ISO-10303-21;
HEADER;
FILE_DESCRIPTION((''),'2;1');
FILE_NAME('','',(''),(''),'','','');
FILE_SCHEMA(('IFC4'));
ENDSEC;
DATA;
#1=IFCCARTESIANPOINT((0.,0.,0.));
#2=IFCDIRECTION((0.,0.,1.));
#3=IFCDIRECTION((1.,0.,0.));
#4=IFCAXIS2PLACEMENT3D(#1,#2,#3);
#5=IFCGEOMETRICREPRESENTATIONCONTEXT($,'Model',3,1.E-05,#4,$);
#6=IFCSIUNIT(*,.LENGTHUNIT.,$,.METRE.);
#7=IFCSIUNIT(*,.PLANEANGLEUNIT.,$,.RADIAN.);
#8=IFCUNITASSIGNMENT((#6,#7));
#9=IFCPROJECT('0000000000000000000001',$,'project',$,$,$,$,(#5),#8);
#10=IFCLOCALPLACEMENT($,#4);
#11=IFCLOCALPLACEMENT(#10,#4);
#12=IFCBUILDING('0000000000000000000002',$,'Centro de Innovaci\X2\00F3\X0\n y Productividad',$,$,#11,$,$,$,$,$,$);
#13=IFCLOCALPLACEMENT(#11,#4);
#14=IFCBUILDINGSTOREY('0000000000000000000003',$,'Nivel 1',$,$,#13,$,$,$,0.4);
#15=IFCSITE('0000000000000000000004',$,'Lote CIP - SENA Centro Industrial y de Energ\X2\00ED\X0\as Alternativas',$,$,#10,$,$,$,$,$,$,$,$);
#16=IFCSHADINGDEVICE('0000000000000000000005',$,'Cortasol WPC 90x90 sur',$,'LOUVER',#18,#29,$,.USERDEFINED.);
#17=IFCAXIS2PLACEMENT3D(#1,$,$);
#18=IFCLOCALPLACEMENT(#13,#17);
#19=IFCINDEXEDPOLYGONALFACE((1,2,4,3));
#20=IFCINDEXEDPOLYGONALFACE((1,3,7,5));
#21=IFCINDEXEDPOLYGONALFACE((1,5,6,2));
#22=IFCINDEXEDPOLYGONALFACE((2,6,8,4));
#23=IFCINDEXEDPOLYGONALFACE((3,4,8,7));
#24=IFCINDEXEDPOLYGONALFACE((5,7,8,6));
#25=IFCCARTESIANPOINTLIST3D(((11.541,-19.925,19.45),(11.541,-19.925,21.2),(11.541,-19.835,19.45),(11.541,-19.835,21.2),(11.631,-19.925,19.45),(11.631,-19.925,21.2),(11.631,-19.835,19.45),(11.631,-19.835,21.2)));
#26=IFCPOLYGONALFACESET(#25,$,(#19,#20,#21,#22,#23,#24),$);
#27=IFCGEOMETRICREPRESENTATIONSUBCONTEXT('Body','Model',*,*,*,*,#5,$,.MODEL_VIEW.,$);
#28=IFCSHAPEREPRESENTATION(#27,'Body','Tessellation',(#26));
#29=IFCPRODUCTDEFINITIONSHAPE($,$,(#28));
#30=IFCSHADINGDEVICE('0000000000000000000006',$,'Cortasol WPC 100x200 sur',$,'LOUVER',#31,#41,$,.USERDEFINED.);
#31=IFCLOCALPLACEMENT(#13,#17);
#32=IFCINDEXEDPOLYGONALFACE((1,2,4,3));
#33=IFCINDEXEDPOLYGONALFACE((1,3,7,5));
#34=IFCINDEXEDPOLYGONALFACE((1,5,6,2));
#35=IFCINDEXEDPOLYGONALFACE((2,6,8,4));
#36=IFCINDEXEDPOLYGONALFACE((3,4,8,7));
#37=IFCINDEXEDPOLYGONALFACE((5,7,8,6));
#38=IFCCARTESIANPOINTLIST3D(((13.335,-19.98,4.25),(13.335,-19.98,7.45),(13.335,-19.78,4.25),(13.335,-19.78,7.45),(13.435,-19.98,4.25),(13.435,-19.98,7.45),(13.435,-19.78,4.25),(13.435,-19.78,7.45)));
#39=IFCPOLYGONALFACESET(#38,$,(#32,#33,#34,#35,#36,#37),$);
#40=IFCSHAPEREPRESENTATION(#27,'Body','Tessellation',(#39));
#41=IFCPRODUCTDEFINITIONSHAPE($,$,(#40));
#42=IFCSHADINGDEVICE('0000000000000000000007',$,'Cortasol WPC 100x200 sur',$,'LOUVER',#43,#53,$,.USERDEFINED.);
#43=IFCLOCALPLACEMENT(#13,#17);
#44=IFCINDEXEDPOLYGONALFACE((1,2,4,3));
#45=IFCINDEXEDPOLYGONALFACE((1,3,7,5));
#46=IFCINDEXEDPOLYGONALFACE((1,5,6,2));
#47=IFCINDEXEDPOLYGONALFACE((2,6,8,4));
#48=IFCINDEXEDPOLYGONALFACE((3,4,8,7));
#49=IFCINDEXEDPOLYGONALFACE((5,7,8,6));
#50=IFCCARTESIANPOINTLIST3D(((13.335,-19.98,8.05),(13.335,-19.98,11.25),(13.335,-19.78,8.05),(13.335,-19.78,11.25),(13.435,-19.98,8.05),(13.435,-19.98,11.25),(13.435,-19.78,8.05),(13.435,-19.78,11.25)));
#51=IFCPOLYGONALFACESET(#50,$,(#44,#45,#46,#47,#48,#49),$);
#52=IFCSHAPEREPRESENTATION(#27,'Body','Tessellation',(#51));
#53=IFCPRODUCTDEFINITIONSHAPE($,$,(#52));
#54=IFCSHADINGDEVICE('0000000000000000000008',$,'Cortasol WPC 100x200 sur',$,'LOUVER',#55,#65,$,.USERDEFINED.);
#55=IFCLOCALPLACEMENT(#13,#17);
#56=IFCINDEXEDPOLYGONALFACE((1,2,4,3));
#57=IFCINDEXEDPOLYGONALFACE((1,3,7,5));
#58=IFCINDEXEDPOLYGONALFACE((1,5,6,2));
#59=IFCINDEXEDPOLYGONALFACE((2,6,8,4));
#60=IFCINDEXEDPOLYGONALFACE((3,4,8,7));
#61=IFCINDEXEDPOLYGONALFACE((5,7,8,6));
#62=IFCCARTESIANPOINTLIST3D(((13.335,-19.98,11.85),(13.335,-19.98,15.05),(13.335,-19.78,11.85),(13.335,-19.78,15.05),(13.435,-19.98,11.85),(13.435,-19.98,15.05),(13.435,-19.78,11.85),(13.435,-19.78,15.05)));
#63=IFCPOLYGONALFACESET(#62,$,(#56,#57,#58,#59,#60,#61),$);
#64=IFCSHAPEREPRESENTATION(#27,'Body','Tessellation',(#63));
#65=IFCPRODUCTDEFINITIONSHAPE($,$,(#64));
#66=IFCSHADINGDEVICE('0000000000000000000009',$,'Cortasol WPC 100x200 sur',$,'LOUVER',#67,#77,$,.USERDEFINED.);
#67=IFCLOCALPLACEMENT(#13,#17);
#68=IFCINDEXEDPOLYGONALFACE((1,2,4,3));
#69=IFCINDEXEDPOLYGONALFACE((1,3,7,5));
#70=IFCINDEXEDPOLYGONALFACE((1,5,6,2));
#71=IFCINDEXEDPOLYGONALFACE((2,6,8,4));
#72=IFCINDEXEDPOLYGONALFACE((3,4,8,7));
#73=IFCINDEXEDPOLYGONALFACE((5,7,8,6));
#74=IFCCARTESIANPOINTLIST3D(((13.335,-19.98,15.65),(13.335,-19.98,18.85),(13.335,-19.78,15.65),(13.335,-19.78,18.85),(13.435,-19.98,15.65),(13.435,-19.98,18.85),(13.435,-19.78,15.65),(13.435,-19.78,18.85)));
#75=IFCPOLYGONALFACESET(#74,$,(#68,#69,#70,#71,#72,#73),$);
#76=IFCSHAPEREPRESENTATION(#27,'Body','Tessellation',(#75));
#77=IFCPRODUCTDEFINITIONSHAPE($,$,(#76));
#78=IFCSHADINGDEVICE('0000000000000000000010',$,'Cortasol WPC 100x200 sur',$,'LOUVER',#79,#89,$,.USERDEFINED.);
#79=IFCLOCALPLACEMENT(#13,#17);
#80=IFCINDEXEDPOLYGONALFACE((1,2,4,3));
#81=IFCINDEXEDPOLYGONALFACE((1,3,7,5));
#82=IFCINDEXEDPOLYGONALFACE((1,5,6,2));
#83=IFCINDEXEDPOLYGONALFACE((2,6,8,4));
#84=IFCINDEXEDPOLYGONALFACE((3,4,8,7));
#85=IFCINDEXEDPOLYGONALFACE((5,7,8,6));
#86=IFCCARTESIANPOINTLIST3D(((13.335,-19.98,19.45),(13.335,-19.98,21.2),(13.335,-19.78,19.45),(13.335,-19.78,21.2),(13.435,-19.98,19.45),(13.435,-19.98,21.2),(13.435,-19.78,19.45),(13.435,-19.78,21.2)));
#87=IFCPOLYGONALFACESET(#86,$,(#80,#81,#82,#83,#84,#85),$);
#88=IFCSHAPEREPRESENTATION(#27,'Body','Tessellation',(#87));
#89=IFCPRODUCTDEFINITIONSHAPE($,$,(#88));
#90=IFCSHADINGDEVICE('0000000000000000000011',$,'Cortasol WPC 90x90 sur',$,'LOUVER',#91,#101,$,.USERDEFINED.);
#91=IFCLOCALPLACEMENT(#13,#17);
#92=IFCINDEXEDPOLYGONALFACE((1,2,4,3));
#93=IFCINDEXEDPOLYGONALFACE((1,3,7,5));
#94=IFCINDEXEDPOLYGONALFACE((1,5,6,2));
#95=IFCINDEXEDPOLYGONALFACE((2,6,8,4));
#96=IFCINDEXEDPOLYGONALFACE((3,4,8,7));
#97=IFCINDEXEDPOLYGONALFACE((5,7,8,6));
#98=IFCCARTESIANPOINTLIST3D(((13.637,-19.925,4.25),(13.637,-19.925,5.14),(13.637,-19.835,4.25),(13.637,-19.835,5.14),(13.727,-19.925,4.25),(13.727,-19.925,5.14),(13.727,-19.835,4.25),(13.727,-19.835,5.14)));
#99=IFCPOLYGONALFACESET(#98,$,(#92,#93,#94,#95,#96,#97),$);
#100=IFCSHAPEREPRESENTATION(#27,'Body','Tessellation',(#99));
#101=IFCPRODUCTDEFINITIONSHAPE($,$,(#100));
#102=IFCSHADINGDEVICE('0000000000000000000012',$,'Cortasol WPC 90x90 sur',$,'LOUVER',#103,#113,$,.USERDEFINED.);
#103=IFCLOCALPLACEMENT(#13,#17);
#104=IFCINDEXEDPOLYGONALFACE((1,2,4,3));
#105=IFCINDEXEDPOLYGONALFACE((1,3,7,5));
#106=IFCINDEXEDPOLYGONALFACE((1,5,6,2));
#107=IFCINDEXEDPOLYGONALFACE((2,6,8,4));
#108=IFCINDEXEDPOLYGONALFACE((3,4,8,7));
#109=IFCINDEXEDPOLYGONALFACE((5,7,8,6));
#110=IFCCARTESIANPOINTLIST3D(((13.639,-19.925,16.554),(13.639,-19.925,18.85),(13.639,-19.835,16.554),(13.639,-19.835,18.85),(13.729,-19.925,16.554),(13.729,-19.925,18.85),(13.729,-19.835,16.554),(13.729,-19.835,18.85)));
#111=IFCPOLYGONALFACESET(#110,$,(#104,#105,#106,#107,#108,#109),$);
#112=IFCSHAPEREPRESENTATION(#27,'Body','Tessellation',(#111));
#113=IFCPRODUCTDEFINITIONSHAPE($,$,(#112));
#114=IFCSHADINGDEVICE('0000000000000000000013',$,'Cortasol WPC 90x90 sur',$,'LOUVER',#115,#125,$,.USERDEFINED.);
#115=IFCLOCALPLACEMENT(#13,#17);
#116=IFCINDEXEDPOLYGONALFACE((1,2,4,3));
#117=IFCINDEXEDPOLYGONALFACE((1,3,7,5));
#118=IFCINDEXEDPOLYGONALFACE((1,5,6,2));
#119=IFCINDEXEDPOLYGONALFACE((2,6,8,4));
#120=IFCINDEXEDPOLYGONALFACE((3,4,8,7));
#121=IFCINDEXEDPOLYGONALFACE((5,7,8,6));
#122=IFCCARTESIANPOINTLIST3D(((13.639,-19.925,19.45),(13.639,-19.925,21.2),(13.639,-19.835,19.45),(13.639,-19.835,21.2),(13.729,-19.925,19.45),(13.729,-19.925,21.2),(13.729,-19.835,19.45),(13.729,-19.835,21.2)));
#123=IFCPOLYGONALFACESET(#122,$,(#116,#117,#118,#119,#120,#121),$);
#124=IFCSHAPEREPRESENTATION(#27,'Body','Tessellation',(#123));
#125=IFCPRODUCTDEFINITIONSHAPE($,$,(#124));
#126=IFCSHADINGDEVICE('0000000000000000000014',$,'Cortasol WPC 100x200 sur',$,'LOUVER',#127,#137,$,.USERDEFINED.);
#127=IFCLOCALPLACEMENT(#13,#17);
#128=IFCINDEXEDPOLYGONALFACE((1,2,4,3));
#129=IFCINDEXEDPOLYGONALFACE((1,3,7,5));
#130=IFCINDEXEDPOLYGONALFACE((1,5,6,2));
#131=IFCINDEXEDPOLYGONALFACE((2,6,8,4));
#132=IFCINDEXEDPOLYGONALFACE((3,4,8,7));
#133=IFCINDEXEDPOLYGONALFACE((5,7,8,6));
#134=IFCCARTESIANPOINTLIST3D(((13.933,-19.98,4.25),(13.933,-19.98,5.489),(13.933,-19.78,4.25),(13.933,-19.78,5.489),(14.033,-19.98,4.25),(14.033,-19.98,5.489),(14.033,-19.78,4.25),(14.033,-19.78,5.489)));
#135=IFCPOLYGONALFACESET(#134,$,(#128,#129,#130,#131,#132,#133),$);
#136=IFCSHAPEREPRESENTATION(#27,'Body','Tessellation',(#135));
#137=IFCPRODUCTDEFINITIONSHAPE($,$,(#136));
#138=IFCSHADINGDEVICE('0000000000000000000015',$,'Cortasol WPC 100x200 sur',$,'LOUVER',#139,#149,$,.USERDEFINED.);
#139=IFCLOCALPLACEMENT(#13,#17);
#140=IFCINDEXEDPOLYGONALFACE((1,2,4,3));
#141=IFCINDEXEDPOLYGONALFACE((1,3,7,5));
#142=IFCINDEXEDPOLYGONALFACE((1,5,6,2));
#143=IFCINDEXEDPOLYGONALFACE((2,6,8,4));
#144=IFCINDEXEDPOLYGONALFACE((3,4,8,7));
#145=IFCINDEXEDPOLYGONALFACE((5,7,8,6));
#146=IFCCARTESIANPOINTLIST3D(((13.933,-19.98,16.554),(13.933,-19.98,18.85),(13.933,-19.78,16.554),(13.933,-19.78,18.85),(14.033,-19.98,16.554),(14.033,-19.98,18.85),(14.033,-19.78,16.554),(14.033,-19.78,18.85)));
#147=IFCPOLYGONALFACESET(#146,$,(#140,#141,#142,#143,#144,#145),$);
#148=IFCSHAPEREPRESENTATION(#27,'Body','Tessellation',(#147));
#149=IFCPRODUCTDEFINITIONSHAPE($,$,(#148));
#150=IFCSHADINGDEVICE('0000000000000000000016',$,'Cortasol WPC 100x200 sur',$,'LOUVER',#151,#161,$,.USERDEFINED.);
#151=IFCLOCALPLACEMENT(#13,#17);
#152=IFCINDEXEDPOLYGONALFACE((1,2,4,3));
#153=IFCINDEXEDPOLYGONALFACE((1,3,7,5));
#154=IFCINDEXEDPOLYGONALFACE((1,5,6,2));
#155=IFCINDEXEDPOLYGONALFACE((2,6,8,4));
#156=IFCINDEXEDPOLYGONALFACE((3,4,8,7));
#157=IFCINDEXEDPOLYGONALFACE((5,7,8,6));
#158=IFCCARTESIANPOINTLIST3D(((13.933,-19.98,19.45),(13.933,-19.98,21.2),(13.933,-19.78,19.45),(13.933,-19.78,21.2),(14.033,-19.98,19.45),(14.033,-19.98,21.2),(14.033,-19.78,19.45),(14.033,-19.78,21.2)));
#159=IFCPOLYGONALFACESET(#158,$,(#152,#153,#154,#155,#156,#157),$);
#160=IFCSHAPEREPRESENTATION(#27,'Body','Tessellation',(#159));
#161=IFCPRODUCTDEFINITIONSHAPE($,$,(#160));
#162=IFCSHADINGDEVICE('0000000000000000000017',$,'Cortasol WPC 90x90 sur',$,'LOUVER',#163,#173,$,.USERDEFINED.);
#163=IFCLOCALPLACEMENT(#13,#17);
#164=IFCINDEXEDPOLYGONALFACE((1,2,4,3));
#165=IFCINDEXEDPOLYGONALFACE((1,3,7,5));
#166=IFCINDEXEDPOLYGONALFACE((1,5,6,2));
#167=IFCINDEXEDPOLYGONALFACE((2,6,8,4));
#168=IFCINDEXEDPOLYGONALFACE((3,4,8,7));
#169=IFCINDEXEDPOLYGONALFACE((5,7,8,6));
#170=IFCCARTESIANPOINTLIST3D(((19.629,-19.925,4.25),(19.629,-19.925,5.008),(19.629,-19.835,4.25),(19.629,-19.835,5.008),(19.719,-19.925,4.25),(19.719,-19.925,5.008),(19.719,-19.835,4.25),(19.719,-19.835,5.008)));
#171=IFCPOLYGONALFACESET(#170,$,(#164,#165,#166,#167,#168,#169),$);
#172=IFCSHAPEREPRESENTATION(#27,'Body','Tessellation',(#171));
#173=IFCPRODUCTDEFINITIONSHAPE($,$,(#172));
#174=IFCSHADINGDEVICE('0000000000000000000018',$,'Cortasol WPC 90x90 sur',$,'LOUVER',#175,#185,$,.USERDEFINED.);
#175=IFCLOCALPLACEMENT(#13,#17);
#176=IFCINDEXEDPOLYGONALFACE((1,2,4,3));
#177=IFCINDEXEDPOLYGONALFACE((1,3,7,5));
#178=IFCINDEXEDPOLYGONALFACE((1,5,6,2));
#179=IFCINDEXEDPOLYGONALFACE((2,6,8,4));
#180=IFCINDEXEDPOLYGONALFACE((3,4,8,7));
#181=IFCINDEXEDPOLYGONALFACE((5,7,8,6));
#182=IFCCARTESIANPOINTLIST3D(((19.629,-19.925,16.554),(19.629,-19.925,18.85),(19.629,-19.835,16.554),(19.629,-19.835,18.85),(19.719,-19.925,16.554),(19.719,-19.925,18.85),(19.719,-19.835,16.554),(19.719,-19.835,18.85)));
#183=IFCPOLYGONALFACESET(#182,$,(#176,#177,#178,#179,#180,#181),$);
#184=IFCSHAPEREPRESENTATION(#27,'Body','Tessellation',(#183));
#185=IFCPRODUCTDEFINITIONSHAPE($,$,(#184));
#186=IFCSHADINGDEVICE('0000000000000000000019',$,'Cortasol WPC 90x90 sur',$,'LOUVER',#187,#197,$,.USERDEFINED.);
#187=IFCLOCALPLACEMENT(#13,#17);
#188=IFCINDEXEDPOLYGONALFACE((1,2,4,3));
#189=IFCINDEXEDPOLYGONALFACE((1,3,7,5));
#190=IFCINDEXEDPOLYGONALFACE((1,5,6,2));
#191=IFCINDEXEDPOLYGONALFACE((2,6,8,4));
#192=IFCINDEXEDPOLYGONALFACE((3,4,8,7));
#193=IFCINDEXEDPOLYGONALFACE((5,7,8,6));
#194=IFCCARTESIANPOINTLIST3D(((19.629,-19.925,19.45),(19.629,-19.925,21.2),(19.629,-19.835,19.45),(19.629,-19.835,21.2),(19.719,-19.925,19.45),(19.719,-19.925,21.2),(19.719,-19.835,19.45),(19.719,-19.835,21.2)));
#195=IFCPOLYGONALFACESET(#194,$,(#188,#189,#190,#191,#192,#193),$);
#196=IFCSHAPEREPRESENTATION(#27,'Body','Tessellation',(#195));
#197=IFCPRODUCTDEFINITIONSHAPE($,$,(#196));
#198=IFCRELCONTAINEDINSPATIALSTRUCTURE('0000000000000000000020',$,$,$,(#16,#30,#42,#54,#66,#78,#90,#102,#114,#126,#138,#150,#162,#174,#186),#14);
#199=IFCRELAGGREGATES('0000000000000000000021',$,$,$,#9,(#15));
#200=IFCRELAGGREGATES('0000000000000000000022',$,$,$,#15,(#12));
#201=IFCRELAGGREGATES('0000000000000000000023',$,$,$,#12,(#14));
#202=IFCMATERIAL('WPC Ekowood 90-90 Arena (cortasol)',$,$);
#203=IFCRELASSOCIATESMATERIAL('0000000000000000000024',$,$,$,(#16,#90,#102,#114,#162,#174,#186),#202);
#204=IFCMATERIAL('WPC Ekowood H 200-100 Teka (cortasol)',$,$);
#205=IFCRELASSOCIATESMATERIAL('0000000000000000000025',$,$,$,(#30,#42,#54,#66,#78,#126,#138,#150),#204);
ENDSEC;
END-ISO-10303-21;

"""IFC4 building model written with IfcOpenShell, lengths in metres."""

from ifc_helpers import new_model, si_unit, frame, origin_with_axes, place, context, subcontext, project, spatial, polyline, outline, extrude, material, element, save


model = new_model("IFC4")

# Units and contexts
model_context = context("Model", 3, precision=1e-05, world=origin_with_axes())
body_context = subcontext(model_context, "Body", "Model", "MODEL_VIEW")
ifc_project = project(units=[si_unit("LENGTHUNIT", "METRE"), si_unit("PLANEANGLEUNIT", "RADIAN")], contexts=[model_context])

# Site, building, storey
site_placement = place(None, origin_with_axes())
site = spatial("IfcSite", under=ifc_project, at=site_placement, Name="Lote CIP - SENA Centro Industrial y de Energías Alternativas")
building_placement = place(site_placement, origin_with_axes())
building = spatial("IfcBuilding", under=site, at=building_placement, Name="Centro de Innovación y Productividad")
storey_placement = place(building_placement, origin_with_axes())
storey = spatial("IfcBuildingStorey", under=building, at=storey_placement, Name="Nivel 1", Elevation=0.4)

# Shading devices
ifc_material_1 = material(Name="WPC Ekowood 90-90 Arena (cortasol)")
shading_device_1_placement = place(storey_placement, origin_with_axes())
element("IfcShadingDevice", 1, at=shading_device_1_placement, inside=storey, material=ifc_material_1, Name="Cortasol WPC 90x90 sur", ObjectType="LOUVER", PredefinedType="USERDEFINED", context=body_context, shape_type="SweptSolid", body=[
    extrude(outline(polyline([(11.541, -19.925), (11.541, -19.835), (11.631, -19.835), (11.631, -19.925), (11.541, -19.925)])), frame((0.0, 0.0, 19.45)), (0.0, 0.0, 1.0), 1.75),
])
ifc_material_2 = material(Name="WPC Ekowood H 200-100 Teka (cortasol)")
shading_device_2_placement = place(storey_placement, origin_with_axes())
element("IfcShadingDevice", 2, at=shading_device_2_placement, inside=storey, material=ifc_material_2, Name="Cortasol WPC 100x200 sur", ObjectType="LOUVER", PredefinedType="USERDEFINED", context=body_context, shape_type="SweptSolid", body=[
    extrude(outline(polyline([(13.335, -19.98), (13.335, -19.78), (13.435, -19.78), (13.435, -19.98), (13.335, -19.98)])), frame((0.0, 0.0, 4.25)), (0.0, 0.0, 1.0), 3.2),
])
shading_device_3_placement = place(storey_placement, origin_with_axes())
element("IfcShadingDevice", 3, at=shading_device_3_placement, inside=storey, material=ifc_material_2, Name="Cortasol WPC 100x200 sur", ObjectType="LOUVER", PredefinedType="USERDEFINED", context=body_context, shape_type="SweptSolid", body=[
    extrude(outline(polyline([(13.335, -19.98), (13.335, -19.78), (13.435, -19.78), (13.435, -19.98), (13.335, -19.98)])), frame((0.0, 0.0, 8.05)), (0.0, 0.0, 1.0), 3.2),
])
shading_device_4_placement = place(storey_placement, origin_with_axes())
element("IfcShadingDevice", 4, at=shading_device_4_placement, inside=storey, material=ifc_material_2, Name="Cortasol WPC 100x200 sur", ObjectType="LOUVER", PredefinedType="USERDEFINED", context=body_context, shape_type="SweptSolid", body=[
    extrude(outline(polyline([(13.335, -19.98), (13.335, -19.78), (13.435, -19.78), (13.435, -19.98), (13.335, -19.98)])), frame((0.0, 0.0, 11.85)), (0.0, 0.0, 1.0), 3.2),
])
shading_device_5_placement = place(storey_placement, origin_with_axes())
element("IfcShadingDevice", 5, at=shading_device_5_placement, inside=storey, material=ifc_material_2, Name="Cortasol WPC 100x200 sur", ObjectType="LOUVER", PredefinedType="USERDEFINED", context=body_context, shape_type="SweptSolid", body=[
    extrude(outline(polyline([(13.335, -19.98), (13.335, -19.78), (13.435, -19.78), (13.435, -19.98), (13.335, -19.98)])), frame((0.0, 0.0, 15.65)), (0.0, 0.0, 1.0), 3.2),
])
shading_device_6_placement = place(storey_placement, origin_with_axes())
element("IfcShadingDevice", 6, at=shading_device_6_placement, inside=storey, material=ifc_material_2, Name="Cortasol WPC 100x200 sur", ObjectType="LOUVER", PredefinedType="USERDEFINED", context=body_context, shape_type="SweptSolid", body=[
    extrude(outline(polyline([(13.335, -19.98), (13.335, -19.78), (13.435, -19.78), (13.435, -19.98), (13.335, -19.98)])), frame((0.0, 0.0, 19.45)), (0.0, 0.0, 1.0), 1.75),
])
shading_device_7_placement = place(storey_placement, origin_with_axes())
element("IfcShadingDevice", 7, at=shading_device_7_placement, inside=storey, material=ifc_material_1, Name="Cortasol WPC 90x90 sur", ObjectType="LOUVER", PredefinedType="USERDEFINED", context=body_context, shape_type="SweptSolid", body=[
    extrude(outline(polyline([(13.637, -19.925), (13.637, -19.835), (13.727, -19.835), (13.727, -19.925), (13.637, -19.925)])), frame((0.0, 0.0, 4.25)), (0.0, 0.0, 1.0), 0.89),
])
shading_device_8_placement = place(storey_placement, origin_with_axes())
element("IfcShadingDevice", 8, at=shading_device_8_placement, inside=storey, material=ifc_material_1, Name="Cortasol WPC 90x90 sur", ObjectType="LOUVER", PredefinedType="USERDEFINED", context=body_context, shape_type="SweptSolid", body=[
    extrude(outline(polyline([(13.639, -19.925), (13.639, -19.835), (13.729, -19.835), (13.729, -19.925), (13.639, -19.925)])), frame((0.0, 0.0, 16.554)), (0.0, 0.0, 1.0), 2.296),
])
shading_device_9_placement = place(storey_placement, origin_with_axes())
element("IfcShadingDevice", 9, at=shading_device_9_placement, inside=storey, material=ifc_material_1, Name="Cortasol WPC 90x90 sur", ObjectType="LOUVER", PredefinedType="USERDEFINED", context=body_context, shape_type="SweptSolid", body=[
    extrude(outline(polyline([(13.639, -19.925), (13.639, -19.835), (13.729, -19.835), (13.729, -19.925), (13.639, -19.925)])), frame((0.0, 0.0, 19.45)), (0.0, 0.0, 1.0), 1.75),
])
shading_device_10_placement = place(storey_placement, origin_with_axes())
element("IfcShadingDevice", 10, at=shading_device_10_placement, inside=storey, material=ifc_material_2, Name="Cortasol WPC 100x200 sur", ObjectType="LOUVER", PredefinedType="USERDEFINED", context=body_context, shape_type="SweptSolid", body=[
    extrude(outline(polyline([(13.933, -19.98), (13.933, -19.78), (14.033, -19.78), (14.033, -19.98), (13.933, -19.98)])), frame((0.0, 0.0, 4.25)), (0.0, 0.0, 1.0), 1.239),
])
shading_device_11_placement = place(storey_placement, origin_with_axes())
element("IfcShadingDevice", 11, at=shading_device_11_placement, inside=storey, material=ifc_material_2, Name="Cortasol WPC 100x200 sur", ObjectType="LOUVER", PredefinedType="USERDEFINED", context=body_context, shape_type="SweptSolid", body=[
    extrude(outline(polyline([(13.933, -19.98), (13.933, -19.78), (14.033, -19.78), (14.033, -19.98), (13.933, -19.98)])), frame((0.0, 0.0, 16.554)), (0.0, 0.0, 1.0), 2.296),
])
shading_device_12_placement = place(storey_placement, origin_with_axes())
element("IfcShadingDevice", 12, at=shading_device_12_placement, inside=storey, material=ifc_material_2, Name="Cortasol WPC 100x200 sur", ObjectType="LOUVER", PredefinedType="USERDEFINED", context=body_context, shape_type="SweptSolid", body=[
    extrude(outline(polyline([(13.933, -19.98), (13.933, -19.78), (14.033, -19.78), (14.033, -19.98), (13.933, -19.98)])), frame((0.0, 0.0, 19.45)), (0.0, 0.0, 1.0), 1.75),
])
shading_device_13_placement = place(storey_placement, origin_with_axes())
element("IfcShadingDevice", 13, at=shading_device_13_placement, inside=storey, material=ifc_material_1, Name="Cortasol WPC 90x90 sur", ObjectType="LOUVER", PredefinedType="USERDEFINED", context=body_context, shape_type="SweptSolid", body=[
    extrude(outline(polyline([(19.629, -19.925), (19.629, -19.835), (19.719, -19.835), (19.719, -19.925), (19.629, -19.925)])), frame((0.0, 0.0, 4.25)), (0.0, 0.0, 1.0), 0.758),
])
shading_device_14_placement = place(storey_placement, origin_with_axes())
element("IfcShadingDevice", 14, at=shading_device_14_placement, inside=storey, material=ifc_material_1, Name="Cortasol WPC 90x90 sur", ObjectType="LOUVER", PredefinedType="USERDEFINED", context=body_context, shape_type="SweptSolid", body=[
    extrude(outline(polyline([(19.629, -19.925), (19.629, -19.835), (19.719, -19.835), (19.719, -19.925), (19.629, -19.925)])), frame((0.0, 0.0, 16.554)), (0.0, 0.0, 1.0), 2.296),
])
shading_device_15_placement = place(storey_placement, origin_with_axes())
element("IfcShadingDevice", 15, at=shading_device_15_placement, inside=storey, material=ifc_material_1, Name="Cortasol WPC 90x90 sur", ObjectType="LOUVER", PredefinedType="USERDEFINED", context=body_context, shape_type="SweptSolid", body=[
    extrude(outline(polyline([(19.629, -19.925), (19.629, -19.835), (19.719, -19.835), (19.719, -19.925), (19.629, -19.925)])), frame((0.0, 0.0, 19.45)), (0.0, 0.0, 1.0), 1.75),
])

save(model, "model.ifc")
